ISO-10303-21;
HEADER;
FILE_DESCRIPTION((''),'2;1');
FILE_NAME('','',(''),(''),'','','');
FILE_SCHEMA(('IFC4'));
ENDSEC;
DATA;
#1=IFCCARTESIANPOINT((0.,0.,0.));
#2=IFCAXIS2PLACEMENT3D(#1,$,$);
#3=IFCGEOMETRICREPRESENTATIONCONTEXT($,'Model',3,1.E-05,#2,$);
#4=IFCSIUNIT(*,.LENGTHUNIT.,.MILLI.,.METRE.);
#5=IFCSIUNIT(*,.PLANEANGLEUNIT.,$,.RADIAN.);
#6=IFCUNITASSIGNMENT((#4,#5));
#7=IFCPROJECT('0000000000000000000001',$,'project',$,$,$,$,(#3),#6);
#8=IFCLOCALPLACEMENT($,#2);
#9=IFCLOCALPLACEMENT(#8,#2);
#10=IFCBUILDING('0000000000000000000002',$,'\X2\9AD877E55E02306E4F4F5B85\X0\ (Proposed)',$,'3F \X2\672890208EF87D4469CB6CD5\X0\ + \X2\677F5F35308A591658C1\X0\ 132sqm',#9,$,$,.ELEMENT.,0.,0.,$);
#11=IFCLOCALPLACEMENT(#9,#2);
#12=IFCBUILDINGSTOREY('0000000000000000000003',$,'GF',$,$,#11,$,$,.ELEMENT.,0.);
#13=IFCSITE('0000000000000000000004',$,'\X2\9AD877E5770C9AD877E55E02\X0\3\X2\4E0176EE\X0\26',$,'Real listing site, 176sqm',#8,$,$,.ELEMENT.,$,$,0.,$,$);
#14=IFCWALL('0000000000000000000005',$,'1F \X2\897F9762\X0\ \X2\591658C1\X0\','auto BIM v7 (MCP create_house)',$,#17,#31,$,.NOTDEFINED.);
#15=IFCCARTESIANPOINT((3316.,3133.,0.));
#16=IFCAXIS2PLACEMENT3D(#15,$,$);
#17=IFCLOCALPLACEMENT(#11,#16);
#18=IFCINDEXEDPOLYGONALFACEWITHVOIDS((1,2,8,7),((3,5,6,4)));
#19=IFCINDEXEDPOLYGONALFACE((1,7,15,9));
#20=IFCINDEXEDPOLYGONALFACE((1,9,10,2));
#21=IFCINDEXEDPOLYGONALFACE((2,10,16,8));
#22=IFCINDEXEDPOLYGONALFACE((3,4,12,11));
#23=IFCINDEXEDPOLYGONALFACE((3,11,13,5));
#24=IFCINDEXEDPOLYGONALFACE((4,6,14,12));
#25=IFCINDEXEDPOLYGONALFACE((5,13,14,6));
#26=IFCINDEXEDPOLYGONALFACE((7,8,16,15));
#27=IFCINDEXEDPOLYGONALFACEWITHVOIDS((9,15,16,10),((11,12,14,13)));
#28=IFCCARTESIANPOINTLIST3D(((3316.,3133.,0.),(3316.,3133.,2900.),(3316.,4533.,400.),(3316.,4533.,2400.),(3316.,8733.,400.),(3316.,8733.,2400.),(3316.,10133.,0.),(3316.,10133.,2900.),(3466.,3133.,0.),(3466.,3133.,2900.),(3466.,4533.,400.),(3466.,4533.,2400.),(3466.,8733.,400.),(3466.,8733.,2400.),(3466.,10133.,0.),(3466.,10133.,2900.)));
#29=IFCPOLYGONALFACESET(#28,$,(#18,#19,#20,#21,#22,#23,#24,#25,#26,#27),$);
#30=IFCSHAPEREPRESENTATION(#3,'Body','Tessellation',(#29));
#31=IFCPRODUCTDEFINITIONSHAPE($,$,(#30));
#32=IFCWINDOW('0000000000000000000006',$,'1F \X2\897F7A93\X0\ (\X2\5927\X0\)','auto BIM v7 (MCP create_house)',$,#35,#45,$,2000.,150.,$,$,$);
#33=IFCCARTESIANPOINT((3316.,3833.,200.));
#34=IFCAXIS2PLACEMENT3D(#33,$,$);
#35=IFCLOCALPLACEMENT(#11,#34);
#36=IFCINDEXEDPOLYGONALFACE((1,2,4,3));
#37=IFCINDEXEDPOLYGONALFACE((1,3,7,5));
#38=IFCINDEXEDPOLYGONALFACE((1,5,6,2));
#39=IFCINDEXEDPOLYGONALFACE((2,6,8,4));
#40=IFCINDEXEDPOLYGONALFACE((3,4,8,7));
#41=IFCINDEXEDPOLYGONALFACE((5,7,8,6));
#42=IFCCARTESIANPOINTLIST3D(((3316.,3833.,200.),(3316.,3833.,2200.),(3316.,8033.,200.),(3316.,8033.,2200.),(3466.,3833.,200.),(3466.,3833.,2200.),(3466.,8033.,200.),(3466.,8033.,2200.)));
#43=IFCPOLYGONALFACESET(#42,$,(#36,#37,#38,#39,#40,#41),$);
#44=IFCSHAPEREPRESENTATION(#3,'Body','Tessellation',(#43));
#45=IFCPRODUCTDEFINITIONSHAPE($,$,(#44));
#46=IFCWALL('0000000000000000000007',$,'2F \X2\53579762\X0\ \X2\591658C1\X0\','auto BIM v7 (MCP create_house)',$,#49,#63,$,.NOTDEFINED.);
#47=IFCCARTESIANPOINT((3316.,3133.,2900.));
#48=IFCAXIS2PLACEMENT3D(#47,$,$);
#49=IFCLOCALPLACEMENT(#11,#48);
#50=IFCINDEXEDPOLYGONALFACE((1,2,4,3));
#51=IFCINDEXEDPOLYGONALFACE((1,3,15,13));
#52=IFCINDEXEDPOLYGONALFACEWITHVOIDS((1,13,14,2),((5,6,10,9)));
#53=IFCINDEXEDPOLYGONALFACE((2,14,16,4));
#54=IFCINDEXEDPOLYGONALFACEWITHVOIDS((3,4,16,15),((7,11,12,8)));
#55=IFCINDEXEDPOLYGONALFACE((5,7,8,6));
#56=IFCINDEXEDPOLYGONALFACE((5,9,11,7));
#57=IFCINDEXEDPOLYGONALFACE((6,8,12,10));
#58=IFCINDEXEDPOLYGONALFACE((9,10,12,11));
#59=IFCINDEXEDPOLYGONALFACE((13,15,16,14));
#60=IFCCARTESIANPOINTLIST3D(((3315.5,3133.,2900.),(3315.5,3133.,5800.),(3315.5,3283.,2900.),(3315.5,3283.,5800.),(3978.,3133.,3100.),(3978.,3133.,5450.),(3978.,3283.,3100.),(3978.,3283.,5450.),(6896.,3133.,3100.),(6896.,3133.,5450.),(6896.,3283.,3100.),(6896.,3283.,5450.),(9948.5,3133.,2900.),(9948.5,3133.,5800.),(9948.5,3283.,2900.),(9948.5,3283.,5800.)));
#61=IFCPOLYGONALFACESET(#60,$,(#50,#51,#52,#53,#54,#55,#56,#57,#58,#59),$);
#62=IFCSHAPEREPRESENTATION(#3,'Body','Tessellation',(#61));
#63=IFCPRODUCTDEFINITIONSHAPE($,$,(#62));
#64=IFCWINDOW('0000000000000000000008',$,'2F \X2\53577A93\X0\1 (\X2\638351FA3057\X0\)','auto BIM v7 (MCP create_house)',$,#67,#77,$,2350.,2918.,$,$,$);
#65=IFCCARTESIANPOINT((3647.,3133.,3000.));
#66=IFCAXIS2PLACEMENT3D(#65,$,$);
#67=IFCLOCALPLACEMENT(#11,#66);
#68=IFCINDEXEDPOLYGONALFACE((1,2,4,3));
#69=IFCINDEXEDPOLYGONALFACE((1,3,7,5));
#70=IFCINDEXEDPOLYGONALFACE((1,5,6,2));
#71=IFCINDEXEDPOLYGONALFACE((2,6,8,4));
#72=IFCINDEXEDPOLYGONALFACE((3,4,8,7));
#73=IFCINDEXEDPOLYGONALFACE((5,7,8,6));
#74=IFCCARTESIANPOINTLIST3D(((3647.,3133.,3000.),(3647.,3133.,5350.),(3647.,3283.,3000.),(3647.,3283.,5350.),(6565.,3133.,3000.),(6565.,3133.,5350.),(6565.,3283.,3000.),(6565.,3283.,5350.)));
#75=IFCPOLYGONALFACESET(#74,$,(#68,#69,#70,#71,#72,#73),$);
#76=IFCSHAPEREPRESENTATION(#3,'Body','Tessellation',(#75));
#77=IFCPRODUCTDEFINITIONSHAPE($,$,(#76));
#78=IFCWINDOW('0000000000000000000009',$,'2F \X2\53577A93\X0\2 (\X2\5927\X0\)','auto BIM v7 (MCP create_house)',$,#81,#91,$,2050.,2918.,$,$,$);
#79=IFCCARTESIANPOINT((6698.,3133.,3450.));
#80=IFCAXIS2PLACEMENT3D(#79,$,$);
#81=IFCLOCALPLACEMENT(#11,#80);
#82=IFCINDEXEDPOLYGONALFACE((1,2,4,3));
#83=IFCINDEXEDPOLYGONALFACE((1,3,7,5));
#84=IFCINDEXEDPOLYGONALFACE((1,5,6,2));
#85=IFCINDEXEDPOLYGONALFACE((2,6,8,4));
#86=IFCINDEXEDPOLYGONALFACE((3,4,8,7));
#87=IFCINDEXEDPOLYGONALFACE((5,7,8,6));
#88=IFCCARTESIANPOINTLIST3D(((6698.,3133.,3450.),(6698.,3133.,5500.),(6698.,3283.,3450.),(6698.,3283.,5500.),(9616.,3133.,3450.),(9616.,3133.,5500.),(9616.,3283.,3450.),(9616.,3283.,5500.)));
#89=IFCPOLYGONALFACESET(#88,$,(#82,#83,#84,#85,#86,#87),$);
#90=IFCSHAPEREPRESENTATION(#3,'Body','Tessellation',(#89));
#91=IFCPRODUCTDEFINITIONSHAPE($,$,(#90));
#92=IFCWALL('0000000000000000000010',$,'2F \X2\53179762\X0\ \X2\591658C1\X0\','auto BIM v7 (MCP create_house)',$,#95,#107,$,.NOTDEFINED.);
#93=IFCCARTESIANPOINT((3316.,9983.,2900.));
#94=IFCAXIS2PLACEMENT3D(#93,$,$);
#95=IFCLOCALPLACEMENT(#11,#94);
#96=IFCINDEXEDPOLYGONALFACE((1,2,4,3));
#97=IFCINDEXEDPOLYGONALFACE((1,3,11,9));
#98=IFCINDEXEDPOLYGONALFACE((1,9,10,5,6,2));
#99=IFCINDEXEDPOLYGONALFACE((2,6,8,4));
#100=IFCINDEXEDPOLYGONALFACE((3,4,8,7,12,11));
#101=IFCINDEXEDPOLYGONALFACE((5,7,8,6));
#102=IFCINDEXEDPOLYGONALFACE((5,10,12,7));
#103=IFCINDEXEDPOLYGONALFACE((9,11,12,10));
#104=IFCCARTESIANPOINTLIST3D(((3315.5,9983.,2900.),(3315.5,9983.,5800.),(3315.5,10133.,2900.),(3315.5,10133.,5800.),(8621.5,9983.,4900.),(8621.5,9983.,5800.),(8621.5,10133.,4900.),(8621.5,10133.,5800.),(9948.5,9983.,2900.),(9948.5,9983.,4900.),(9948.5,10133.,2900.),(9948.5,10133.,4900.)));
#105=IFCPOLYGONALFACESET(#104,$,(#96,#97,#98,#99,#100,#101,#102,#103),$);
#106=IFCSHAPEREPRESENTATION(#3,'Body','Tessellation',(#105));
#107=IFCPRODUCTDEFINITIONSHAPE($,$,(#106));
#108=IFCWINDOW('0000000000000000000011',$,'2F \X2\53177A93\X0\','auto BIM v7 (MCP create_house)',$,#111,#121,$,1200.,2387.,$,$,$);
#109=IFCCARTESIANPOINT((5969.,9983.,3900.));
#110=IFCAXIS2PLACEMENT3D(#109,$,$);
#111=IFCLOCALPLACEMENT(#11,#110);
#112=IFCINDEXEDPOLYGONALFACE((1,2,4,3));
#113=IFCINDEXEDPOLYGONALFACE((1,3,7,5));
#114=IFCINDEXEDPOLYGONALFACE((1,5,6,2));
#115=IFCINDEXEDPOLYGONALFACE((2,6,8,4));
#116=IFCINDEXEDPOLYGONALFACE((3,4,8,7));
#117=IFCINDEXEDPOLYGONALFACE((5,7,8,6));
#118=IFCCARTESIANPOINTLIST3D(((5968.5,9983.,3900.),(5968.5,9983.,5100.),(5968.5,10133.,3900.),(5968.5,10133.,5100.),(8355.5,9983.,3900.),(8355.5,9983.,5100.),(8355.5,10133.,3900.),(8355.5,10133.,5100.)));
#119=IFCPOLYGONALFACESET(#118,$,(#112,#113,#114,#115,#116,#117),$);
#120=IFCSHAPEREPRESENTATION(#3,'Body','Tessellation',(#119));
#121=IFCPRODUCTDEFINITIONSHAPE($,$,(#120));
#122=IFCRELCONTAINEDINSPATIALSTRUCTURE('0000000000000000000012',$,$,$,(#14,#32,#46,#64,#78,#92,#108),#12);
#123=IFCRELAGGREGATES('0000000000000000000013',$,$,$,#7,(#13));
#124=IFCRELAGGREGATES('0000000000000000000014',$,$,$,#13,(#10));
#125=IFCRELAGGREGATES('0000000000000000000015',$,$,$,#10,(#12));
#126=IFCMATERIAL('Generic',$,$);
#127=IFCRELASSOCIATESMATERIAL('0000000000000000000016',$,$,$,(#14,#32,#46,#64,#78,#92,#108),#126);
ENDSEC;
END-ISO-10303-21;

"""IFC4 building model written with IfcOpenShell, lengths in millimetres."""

from ifc_helpers import new_model, si_unit, frame, frame_2d, origin, place, context, project, spatial, rectangle, extrude, material, element, fill, save


model = new_model("IFC4")

# Units and contexts
model_context = context("Model", 3, precision=1e-05, world=origin())
ifc_project = project(units=[si_unit("LENGTHUNIT", "METRE", prefix="MILLI"), si_unit("PLANEANGLEUNIT", "RADIAN")], contexts=[model_context])

# Site, building, storey
site_placement = place(None, origin())
site = spatial("IfcSite", under=ifc_project, at=site_placement, Name="高知県高知市3丁目26", ObjectType="Real listing site, 176sqm", CompositionType="ELEMENT", RefElevation=0.0)
building_placement = place(site_placement, origin())
building = spatial("IfcBuilding", under=site, at=building_placement, Name="高知市の住宅 (Proposed)", ObjectType="3F 木造軸組構法 + 板張り外壁 132sqm", CompositionType="ELEMENT", ElevationOfRefHeight=0.0, ElevationOfTerrain=0.0)
storey_placement = place(building_placement, origin())
storey = spatial("IfcBuildingStorey", under=building, at=storey_placement, Name="GF", CompositionType="ELEMENT", Elevation=0.0)

# Shared definitions
ifc_material = material(Name="Generic")

# Wall, opening, window
wall_1_placement = place(storey_placement, frame((3316.0, 3133.0, 0.0)))
wall_1 = element("IfcWall", 1, at=wall_1_placement, inside=storey, material=ifc_material, Name="1F 西面 外壁", Description="auto BIM v7 (MCP create_house)", PredefinedType="NOTDEFINED", context=model_context, shape_type="SweptSolid", body=[
    extrude(rectangle(XDim=150.0, YDim=7000.0, at=frame_2d((75.0, 3500.0))), frame((3316.0, 3133.0, 0.0)), (0.0, 0.0, 1.0), 2900.0),
])
opening_1_placement = place(storey_placement, frame((3316.0, 3833.0, 200.0)))
opening_1 = element("IfcOpeningElement", 2, at=opening_1_placement, cuts=wall_1, PredefinedType="NOTDEFINED", context=model_context, shape_type="SweptSolid", body=[
    extrude(rectangle(XDim=150.0, YDim=4200.0, at=frame_2d((75.0, 2100.0))), frame((3316.0, 3833.0, 200.0)), (0.0, 0.0, 1.0), 2000.0),
])
window_1_placement = place(storey_placement, frame((3316.0, 3833.0, 200.0)))
window_1 = element("IfcWindow", 3, at=window_1_placement, inside=storey, material=ifc_material, Name="1F 西窓 (大)", Description="auto BIM v7 (MCP create_house)", OverallHeight=2000.0, OverallWidth=150.0, context=model_context, shape_type="SweptSolid", body=[
    extrude(rectangle(XDim=150.0, YDim=4200.0, at=frame_2d((75.0, 2100.0))), frame((3316.0, 3833.0, 200.0)), (0.0, 0.0, 1.0), 2000.0),
])
fill(opening_1, window_1)

# Wall, openings, windows
wall_2_placement = place(storey_placement, frame((3316.0, 3133.0, 2900.0)))
wall_2 = element("IfcWall", 4, at=wall_2_placement, inside=storey, material=ifc_material, Name="2F 南面 外壁", Description="auto BIM v7 (MCP create_house)", PredefinedType="NOTDEFINED", context=model_context, shape_type="SweptSolid", body=[
    extrude(rectangle(XDim=6633.0, YDim=150.0, at=frame_2d((3316.0, 75.0))), frame((3316.0, 3133.0, 2900.0)), (0.0, 0.0, 1.0), 2900.0),
])
opening_2_placement = place(storey_placement, frame((3647.0, 3133.0, 3000.0)))
opening_2 = element("IfcOpeningElement", 5, at=opening_2_placement, cuts=wall_2, PredefinedType="NOTDEFINED", context=model_context, shape_type="SweptSolid", body=[
    extrude(rectangle(XDim=2918.0, YDim=150.0, at=frame_2d((1459.0, 75.0))), frame((3647.0, 3133.0, 3000.0)), (0.0, 0.0, 1.0), 2350.0),
])
opening_3_placement = place(storey_placement, frame((6698.0, 3133.0, 3450.0)))
opening_3 = element("IfcOpeningElement", 6, at=opening_3_placement, cuts=wall_2, PredefinedType="NOTDEFINED", context=model_context, shape_type="SweptSolid", body=[
    extrude(rectangle(XDim=2918.0, YDim=150.0, at=frame_2d((1459.0, 75.0))), frame((6698.0, 3133.0, 3450.0)), (0.0, 0.0, 1.0), 2050.0),
])
window_2_placement = place(storey_placement, frame((3647.0, 3133.0, 3000.0)))
window_2 = element("IfcWindow", 7, at=window_2_placement, inside=storey, material=ifc_material, Name="2F 南窓1 (掃出し)", Description="auto BIM v7 (MCP create_house)", OverallHeight=2350.0, OverallWidth=2918.0, context=model_context, shape_type="SweptSolid", body=[
    extrude(rectangle(XDim=2918.0, YDim=150.0, at=frame_2d((1459.0, 75.0))), frame((3647.0, 3133.0, 3000.0)), (0.0, 0.0, 1.0), 2350.0),
])
fill(opening_2, window_2)
window_3_placement = place(storey_placement, frame((6698.0, 3133.0, 3450.0)))
window_3 = element("IfcWindow", 8, at=window_3_placement, inside=storey, material=ifc_material, Name="2F 南窓2 (大)", Description="auto BIM v7 (MCP create_house)", OverallHeight=2050.0, OverallWidth=2918.0, context=model_context, shape_type="SweptSolid", body=[
    extrude(rectangle(XDim=2918.0, YDim=150.0, at=frame_2d((1459.0, 75.0))), frame((6698.0, 3133.0, 3450.0)), (0.0, 0.0, 1.0), 2050.0),
])
fill(opening_3, window_3)

# Wall, opening, window
wall_3_placement = place(storey_placement, frame((3316.0, 9983.0, 2900.0)))
wall_3 = element("IfcWall", 9, at=wall_3_placement, inside=storey, material=ifc_material, Name="2F 北面 外壁", Description="auto BIM v7 (MCP create_house)", PredefinedType="NOTDEFINED", context=model_context, shape_type="SweptSolid", body=[
    extrude(rectangle(XDim=6633.0, YDim=150.0, at=frame_2d((3316.0, 75.0))), frame((3316.0, 9983.0, 2900.0)), (0.0, 0.0, 1.0), 2900.0),
])
opening_4_placement = place(storey_placement, frame((5969.0, 9983.0, 3900.0)))
opening_4 = element("IfcOpeningElement", 10, at=opening_4_placement, cuts=wall_3, PredefinedType="NOTDEFINED", context=model_context, shape_type="SweptSolid", body=[
    extrude(rectangle(XDim=2387.0, YDim=150.0, at=frame_2d((1193.0, 75.0))), frame((5969.0, 9983.0, 3900.0)), (0.0, 0.0, 1.0), 1200.0),
])
window_4_placement = place(storey_placement, frame((5969.0, 9983.0, 3900.0)))
window_4 = element("IfcWindow", 11, at=window_4_placement, inside=storey, material=ifc_material, Name="2F 北窓", Description="auto BIM v7 (MCP create_house)", OverallHeight=1200.0, OverallWidth=2387.0, context=model_context, shape_type="SweptSolid", body=[
    extrude(rectangle(XDim=2387.0, YDim=150.0, at=frame_2d((1193.0, 75.0))), frame((5969.0, 9983.0, 3900.0)), (0.0, 0.0, 1.0), 1200.0),
])
fill(opening_4, window_4)

save(model, "model.ifc")
